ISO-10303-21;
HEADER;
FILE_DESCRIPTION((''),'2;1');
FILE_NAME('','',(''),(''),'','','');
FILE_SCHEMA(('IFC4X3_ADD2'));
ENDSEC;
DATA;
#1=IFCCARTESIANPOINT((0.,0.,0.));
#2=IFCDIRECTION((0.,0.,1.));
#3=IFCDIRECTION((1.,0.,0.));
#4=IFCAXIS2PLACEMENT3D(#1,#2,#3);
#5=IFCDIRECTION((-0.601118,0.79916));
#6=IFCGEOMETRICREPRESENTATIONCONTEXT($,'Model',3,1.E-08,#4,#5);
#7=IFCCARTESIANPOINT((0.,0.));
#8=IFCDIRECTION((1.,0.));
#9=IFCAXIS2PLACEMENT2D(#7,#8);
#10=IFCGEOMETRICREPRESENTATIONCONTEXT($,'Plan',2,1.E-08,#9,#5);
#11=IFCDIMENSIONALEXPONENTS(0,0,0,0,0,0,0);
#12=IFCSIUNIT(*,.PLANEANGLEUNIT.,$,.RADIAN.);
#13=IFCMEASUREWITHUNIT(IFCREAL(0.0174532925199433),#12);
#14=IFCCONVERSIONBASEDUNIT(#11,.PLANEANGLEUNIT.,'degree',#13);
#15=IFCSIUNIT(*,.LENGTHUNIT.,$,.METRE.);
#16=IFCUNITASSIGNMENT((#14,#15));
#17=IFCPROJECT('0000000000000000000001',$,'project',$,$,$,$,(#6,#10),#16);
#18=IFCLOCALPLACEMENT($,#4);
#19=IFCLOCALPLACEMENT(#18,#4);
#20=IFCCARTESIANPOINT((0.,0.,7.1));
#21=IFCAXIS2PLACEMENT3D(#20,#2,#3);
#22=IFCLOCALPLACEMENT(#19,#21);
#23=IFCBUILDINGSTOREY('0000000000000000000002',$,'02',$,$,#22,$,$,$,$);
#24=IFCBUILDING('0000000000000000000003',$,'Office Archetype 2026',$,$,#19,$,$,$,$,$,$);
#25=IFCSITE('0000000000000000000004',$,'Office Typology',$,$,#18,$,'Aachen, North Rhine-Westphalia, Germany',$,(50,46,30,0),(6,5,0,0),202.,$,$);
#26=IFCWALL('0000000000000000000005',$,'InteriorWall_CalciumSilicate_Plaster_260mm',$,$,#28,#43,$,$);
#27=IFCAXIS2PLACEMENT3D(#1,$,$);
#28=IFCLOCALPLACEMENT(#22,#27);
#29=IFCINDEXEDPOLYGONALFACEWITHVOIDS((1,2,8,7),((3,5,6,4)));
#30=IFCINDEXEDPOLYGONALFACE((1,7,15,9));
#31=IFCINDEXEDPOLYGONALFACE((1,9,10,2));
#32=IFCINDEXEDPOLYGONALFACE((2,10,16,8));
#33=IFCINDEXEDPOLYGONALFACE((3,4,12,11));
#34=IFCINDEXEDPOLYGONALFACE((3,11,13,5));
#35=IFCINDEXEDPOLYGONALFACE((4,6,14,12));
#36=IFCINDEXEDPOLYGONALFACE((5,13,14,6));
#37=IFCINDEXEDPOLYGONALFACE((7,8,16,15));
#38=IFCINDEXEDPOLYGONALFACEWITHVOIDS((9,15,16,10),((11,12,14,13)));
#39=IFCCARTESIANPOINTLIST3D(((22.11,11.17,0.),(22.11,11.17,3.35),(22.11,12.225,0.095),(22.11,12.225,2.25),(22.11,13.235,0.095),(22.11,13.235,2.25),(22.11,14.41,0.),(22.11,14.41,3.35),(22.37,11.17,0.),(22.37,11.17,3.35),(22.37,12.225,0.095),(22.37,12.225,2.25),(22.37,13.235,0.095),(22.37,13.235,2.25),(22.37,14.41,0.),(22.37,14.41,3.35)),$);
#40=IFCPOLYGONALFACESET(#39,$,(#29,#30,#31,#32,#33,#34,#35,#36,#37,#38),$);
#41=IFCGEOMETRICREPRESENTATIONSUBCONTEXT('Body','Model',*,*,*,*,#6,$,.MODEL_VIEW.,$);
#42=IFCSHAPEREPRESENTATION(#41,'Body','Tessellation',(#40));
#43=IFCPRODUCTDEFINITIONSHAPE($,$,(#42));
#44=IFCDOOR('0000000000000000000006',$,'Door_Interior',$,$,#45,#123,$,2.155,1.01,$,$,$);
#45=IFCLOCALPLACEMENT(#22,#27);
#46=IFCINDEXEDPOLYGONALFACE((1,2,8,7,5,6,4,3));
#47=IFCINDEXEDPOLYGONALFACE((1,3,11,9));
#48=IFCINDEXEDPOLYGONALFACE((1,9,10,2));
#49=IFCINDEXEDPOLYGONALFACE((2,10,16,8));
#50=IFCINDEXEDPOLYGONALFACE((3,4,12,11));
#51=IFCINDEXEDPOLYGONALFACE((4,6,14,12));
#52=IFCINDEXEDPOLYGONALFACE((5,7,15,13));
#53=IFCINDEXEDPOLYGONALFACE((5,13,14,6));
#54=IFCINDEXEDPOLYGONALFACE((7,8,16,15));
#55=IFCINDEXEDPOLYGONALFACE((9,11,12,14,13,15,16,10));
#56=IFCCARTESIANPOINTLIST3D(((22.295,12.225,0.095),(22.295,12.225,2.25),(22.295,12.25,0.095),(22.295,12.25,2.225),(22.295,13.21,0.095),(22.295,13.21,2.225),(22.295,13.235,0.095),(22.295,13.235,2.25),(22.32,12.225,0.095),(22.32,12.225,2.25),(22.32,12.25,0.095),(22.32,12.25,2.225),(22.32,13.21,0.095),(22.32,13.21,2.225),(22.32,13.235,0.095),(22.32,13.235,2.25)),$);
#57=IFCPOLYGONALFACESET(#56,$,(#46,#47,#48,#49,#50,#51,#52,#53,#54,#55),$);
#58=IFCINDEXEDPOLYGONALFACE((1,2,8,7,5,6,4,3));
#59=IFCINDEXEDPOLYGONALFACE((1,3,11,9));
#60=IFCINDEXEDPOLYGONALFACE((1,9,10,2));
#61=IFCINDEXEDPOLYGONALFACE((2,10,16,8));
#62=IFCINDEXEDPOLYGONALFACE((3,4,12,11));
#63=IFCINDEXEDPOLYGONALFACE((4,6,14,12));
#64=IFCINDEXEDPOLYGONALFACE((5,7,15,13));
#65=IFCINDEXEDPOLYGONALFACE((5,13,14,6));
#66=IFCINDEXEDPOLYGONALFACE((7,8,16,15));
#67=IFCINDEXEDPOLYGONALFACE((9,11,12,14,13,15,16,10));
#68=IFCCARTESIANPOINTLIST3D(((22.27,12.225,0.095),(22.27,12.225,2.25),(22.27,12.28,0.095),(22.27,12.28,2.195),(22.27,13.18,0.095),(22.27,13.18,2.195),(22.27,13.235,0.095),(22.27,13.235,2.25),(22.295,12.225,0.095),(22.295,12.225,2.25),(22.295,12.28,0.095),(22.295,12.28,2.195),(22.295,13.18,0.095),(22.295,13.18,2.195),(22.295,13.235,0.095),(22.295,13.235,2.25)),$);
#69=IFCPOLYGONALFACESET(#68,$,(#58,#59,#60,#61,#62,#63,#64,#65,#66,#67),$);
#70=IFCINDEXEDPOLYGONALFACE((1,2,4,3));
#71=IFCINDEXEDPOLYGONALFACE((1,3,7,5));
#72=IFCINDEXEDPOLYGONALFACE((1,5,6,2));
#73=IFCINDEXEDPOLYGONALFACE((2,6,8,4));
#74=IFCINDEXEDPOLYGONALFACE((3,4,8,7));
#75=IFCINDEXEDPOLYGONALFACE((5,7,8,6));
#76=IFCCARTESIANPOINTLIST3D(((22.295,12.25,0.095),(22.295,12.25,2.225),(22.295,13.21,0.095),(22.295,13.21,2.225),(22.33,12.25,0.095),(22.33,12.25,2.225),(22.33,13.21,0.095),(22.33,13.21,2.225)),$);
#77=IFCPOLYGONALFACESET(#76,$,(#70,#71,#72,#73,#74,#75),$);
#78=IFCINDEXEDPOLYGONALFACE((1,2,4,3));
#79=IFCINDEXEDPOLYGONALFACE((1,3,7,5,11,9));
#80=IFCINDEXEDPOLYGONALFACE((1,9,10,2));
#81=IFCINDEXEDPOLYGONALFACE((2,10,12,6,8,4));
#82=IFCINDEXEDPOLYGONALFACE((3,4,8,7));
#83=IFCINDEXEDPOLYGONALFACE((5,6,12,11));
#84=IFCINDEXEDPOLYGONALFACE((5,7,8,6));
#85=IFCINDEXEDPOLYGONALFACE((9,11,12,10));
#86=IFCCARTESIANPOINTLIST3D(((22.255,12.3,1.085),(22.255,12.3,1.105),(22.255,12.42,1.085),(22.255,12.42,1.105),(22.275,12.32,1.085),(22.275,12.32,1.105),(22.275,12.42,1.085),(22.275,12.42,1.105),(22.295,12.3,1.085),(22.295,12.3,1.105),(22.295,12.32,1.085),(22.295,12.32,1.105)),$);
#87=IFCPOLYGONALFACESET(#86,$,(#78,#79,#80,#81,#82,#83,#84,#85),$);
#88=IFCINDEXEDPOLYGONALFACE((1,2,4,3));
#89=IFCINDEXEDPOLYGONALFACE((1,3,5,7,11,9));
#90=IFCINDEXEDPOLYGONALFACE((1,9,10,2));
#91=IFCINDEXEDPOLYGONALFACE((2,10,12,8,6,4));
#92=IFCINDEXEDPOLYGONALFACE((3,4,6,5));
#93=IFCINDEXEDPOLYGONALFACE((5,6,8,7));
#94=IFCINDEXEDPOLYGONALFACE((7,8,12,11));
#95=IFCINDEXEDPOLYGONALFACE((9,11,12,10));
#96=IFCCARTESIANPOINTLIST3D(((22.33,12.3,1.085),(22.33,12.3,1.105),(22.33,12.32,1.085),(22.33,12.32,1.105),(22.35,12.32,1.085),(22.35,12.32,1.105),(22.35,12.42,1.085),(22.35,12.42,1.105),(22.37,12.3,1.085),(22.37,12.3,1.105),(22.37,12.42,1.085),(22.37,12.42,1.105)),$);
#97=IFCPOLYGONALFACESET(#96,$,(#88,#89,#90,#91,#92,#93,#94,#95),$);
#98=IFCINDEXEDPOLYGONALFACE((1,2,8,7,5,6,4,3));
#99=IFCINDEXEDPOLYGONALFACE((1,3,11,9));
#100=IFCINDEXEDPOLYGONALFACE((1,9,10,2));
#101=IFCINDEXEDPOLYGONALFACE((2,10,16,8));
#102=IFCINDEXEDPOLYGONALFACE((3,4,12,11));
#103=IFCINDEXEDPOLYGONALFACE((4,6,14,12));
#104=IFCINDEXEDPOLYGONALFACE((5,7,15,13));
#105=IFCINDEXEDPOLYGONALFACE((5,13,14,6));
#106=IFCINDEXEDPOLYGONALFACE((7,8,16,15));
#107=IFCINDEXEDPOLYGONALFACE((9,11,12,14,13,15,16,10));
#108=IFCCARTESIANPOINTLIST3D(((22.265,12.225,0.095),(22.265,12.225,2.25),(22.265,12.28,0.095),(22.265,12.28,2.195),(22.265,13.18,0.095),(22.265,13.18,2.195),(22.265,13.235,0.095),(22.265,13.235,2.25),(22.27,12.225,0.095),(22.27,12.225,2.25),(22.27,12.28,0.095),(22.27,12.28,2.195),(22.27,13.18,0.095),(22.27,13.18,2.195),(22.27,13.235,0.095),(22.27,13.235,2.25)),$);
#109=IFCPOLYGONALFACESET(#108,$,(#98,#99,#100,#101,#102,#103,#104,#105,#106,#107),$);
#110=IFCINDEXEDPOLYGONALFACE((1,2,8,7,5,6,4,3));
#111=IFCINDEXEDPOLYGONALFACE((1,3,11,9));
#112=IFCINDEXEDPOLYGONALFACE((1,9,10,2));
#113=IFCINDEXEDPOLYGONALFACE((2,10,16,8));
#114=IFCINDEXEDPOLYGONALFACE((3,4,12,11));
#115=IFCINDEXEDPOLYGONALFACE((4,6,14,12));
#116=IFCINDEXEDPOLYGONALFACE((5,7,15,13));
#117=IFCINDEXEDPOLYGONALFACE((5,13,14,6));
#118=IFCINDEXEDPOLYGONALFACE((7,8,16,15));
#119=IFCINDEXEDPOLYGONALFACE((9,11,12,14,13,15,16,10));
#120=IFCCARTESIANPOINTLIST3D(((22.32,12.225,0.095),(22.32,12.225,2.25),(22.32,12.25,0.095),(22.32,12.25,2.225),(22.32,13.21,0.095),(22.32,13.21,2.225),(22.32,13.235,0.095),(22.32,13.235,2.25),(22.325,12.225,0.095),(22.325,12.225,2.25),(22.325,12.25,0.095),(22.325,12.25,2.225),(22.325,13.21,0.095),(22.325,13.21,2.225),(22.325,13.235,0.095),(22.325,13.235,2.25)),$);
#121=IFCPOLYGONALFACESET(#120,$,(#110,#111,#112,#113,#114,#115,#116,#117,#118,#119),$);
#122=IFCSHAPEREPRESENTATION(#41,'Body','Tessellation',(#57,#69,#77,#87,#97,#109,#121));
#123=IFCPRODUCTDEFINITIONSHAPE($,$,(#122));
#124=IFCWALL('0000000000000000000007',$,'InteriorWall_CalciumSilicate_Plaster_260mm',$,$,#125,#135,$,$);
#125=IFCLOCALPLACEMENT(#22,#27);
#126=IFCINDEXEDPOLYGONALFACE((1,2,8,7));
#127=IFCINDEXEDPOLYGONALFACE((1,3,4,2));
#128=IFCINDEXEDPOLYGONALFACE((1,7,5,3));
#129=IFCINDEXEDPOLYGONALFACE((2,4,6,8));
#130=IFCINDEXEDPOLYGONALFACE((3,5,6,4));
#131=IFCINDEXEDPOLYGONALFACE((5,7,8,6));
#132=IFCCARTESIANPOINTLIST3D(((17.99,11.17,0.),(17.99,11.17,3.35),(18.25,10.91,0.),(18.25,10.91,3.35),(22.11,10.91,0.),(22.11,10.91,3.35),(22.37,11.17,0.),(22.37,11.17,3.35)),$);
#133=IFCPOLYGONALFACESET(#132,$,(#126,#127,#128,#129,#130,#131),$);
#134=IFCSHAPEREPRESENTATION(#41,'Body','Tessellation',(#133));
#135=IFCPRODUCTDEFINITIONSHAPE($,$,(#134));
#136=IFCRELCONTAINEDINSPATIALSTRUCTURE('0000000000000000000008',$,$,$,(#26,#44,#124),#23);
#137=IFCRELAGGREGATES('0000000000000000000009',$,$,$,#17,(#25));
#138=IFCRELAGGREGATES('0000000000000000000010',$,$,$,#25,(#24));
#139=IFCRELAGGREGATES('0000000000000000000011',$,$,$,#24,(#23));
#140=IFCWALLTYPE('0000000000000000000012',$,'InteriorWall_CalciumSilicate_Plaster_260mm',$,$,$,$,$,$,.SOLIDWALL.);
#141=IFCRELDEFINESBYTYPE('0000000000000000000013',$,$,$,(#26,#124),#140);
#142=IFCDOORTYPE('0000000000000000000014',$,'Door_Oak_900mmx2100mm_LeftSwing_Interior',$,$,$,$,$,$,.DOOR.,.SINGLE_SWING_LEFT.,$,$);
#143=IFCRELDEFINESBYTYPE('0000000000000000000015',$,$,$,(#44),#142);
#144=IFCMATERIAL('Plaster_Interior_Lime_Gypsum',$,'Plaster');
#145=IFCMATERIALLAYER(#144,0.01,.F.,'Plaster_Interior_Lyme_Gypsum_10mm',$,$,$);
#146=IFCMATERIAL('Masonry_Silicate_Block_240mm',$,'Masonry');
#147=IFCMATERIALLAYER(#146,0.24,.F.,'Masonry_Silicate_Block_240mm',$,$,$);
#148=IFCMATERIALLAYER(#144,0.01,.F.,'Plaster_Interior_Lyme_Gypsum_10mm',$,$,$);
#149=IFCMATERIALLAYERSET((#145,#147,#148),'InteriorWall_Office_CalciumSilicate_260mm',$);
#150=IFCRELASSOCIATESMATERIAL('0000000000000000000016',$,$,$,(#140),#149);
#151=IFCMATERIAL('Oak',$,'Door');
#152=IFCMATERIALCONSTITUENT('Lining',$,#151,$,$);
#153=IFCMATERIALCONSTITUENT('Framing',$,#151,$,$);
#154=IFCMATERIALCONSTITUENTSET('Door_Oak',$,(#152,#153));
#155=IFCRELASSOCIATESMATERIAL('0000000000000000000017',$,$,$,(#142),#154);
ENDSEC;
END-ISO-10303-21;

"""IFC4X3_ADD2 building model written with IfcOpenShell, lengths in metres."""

from ifc_helpers import new_model, entity, si_unit, converted_unit, direction, frame, origin_with_axes, origin_2d_with_axis, place, context, subcontext, project, spatial, line, indexed_curve, outline, extrude, source, transform, mapped, material, layer, layer_set, constituent, constituent_set, type_object, type_shapes, element, fill, save


model = new_model("IFC4X3_ADD2")

# Units and contexts
model_context = context("Model", 3, precision=1e-08, world=origin_with_axes(), true_north=direction((-0.601118, 0.79916)))
plan_context = context("Plan", 2, precision=1e-08, world=origin_2d_with_axis(), true_north=direction((-0.601118, 0.79916)))
body_context = subcontext(model_context, "Body", "Model", "MODEL_VIEW")
ifc_project = project(units=[converted_unit("PLANEANGLEUNIT", "degree", entity("IfcReal", 0.0174532925199433), si_unit("PLANEANGLEUNIT", "RADIAN"), dimensions=[0, 0, 0, 0, 0, 0, 0]), si_unit("LENGTHUNIT", "METRE")], contexts=[model_context, plan_context])

# Site, building, storey
site_placement = place(None, origin_with_axes())
site = spatial("IfcSite", under=ifc_project, at=site_placement, Name="Office Typology", LongName="Aachen, North Rhine-Westphalia, Germany", RefLatitude=(50, 46, 30, 0), RefLongitude=(6, 5, 0, 0), RefElevation=202.0)
building_placement = place(site_placement, origin_with_axes())
building = spatial("IfcBuilding", under=site, at=building_placement, Name="Office Archetype 2026")
storey_placement = place(building_placement, frame((0.0, 0.0, 7.1), z_axis=(0.0, 0.0, 1.0), x_axis=(1.0, 0.0, 0.0)))
storey = spatial("IfcBuildingStorey", under=building, at=storey_placement, Name="02")

# Wall, opening, door
ifc_material_1 = material(Name="Plaster_Interior_Lime_Gypsum", Category="Plaster")
ifc_layer_1 = layer(ifc_material_1, 0.01, ventilated=False, Name="Plaster_Interior_Lyme_Gypsum_10mm")
ifc_material_2 = material(Name="Masonry_Silicate_Block_240mm", Category="Masonry")
ifc_layer_2 = layer(ifc_material_2, 0.24, ventilated=False, Name="Masonry_Silicate_Block_240mm")
ifc_layer_3 = layer(ifc_material_1, 0.01, ventilated=False, Name="Plaster_Interior_Lyme_Gypsum_10mm")
ifc_layer_set = layer_set([ifc_layer_1, ifc_layer_2, ifc_layer_3], Name="InteriorWall_Office_CalciumSilicate_260mm")
wall_type = type_object("IfcWallType", Name="InteriorWall_CalciumSilicate_Plaster_260mm", PredefinedType="SOLIDWALL", material=ifc_layer_set)
wall_1_placement = place(storey_placement, frame((22.37, 11.17, 0.0), z_axis=(0.0, 0.0, 1.0), x_axis=(0.0, 1.0, 0.0)))
wall_1 = element("IfcWall", 1, at=wall_1_placement, inside=storey, type_object=wall_type, Name="InteriorWall_CalciumSilicate_Plaster_260mm", context=body_context, shape_type="SweptSolid", body=[
    extrude(outline(indexed_curve([(0.0, 0.0), (0.0, 0.26), (3.24, 0.26), (3.24, 0.0)], segments=[line(1, 2, 3, 4, 1)])), origin_with_axes(), (0.0, 0.0, 1.0), 3.35),
])
shared_shape_1 = source(origin_with_axes(), body_context, "Body", "SweptSolid", [
    extrude(outline(indexed_curve([(0.0, 2.155), (1.01, 2.155), (1.01, 0.0), (0.0, 0.0), (0.0, 2.155)])), frame((0.0, -0.015, 0.0), z_axis=(0.0, -1.0, 0.0), x_axis=(1.0, 0.0, 0.0)), (0.0, 0.0, -1.0), 0.26),
])
opening_placement = place(wall_1_placement, frame((2.065, 0.245, 0.095), z_axis=(0.0, 0.0, 1.0), x_axis=(-1.0, 0.0, 0.0)))
opening = element("IfcOpeningElement", 2, at=opening_placement, cuts=wall_1, PredefinedType="OPENING", context=body_context, shape_type="MappedRepresentation", body=[
    mapped(shared_shape_1, transform((0.0, 0.0, 0.0), x_axis=(1.0, 0.0, 0.0), y_axis=(0.0, 1.0, 0.0), z_axis=(0.0, 0.0, 1.0), scale=1.0)),
])
ifc_material_3 = material(Name="Oak", Category="Door")
ifc_constituent_1 = constituent(ifc_material_3, Name="Lining")
ifc_constituent_2 = constituent(ifc_material_3, Name="Framing")
ifc_constituent_set = constituent_set(constituents=[ifc_constituent_1, ifc_constituent_2], Name="Door_Oak")
door_type = type_object("IfcDoorType", Name="Door_Oak_900mmx2100mm_LeftSwing_Interior", OperationType="SINGLE_SWING_LEFT", PredefinedType="DOOR", material=ifc_constituent_set)
shared_shape_2 = source(origin_with_axes(), body_context, "Body", "SweptSolid", [
    extrude(outline(indexed_curve([(0.0, 0.0), (0.0, 2.155), (1.01, 2.155), (1.01, 0.0), (0.985, 0.0), (0.985, 2.13), (0.025, 2.13), (0.025, 0.0)], segments=[line(1, 2, 3, 4, 5, 6, 7, 8, 1)])), frame((0.0, 0.025, 0.0), z_axis=(0.0, -1.0, 0.0), x_axis=(1.0, 0.0, 0.0)), (0.0, 0.0, -1.0), 0.025),
    extrude(outline(indexed_curve([(0.0, 0.0), (0.0, 2.155), (1.01, 2.155), (1.01, 0.0), (0.955, 0.0), (0.955, 2.1), (0.055, 2.1), (0.055, 0.0)], segments=[line(1, 2, 3, 4, 5, 6, 7, 8, 1)])), frame((0.0, 0.0, 0.0), z_axis=(0.0, -1.0, 0.0), x_axis=(1.0, 0.0, 0.0)), (0.0, 0.0, -1.0), 0.025),
    extrude(outline(indexed_curve([(0.0, 0.0), (0.96, 0.0), (0.96, 0.035), (0.0, 0.035)], segments=[line(1, 2, 3, 4, 1)])), frame((0.025, 0.025, 0.0), z_axis=(0.0, 0.0, 1.0), x_axis=(1.0, 0.0, 0.0)), (0.0, 0.0, 1.0), 2.13),
    extrude(outline(indexed_curve([(0.0, 0.0), (0.0, -0.04), (-0.12, -0.04), (-0.12, -0.02), (-0.02, -0.02), (-0.02, 0.0)], segments=[line(1, 2, 3, 4, 5, 6, 1)])), frame((0.935, 0.025, 0.99), z_axis=(0.0, 0.0, 1.0), x_axis=(1.0, 0.0, 0.0)), (0.0, 0.0, 1.0), 0.02),
    extrude(outline(indexed_curve([(0.0, 0.0), (0.0, 0.04), (-0.12, 0.04), (-0.12, 0.02), (-0.02, 0.02), (-0.02, 0.0)], segments=[line(1, 2, 3, 4, 5, 6, 1)])), frame((0.935, 0.06, 0.99), z_axis=(0.0, 0.0, 1.0), x_axis=(1.0, 0.0, 0.0)), (0.0, 0.0, 1.0), 0.02),
    extrude(outline(indexed_curve([(0.0, 0.0), (0.0, 2.155), (1.01, 2.155), (1.01, 0.0), (0.955, 0.0), (0.955, 2.1), (0.055, 2.1), (0.055, 0.0)], segments=[line(1, 2, 3, 4, 5, 6, 7, 8, 1)])), frame((0.0, -0.005, 0.0), z_axis=(0.0, -1.0, 0.0), x_axis=(1.0, 0.0, 0.0)), (0.0, 0.0, -1.0), 0.005),
    extrude(outline(indexed_curve([(0.0, 0.0), (0.0, 2.155), (1.01, 2.155), (1.01, 0.0), (0.985, 0.0), (0.985, 2.13), (0.025, 2.13), (0.025, 0.0)], segments=[line(1, 2, 3, 4, 5, 6, 7, 8, 1)])), frame((0.0, 0.05, 0.0), z_axis=(0.0, -1.0, 0.0), x_axis=(1.0, 0.0, 0.0)), (0.0, 0.0, -1.0), 0.005),
])
type_shapes(door_type, [shared_shape_2])
door_placement = place(opening_placement, frame((0.0, 0.145, 0.0), z_axis=(0.0, 0.0, 1.0), x_axis=(1.0, 0.0, 0.0)))
door = element("IfcDoor", 3, at=door_placement, inside=storey, type_object=door_type, Name="Door_Interior", OverallHeight=2.155, OverallWidth=1.01, context=body_context, shape_type="MappedRepresentation", body=[
    mapped(shared_shape_2, transform((0.0, 0.0, 0.0), x_axis=(1.0, 0.0, 0.0), y_axis=(0.0, 1.0, 0.0), z_axis=(0.0, 0.0, 1.0), scale=1.0)),
])
fill(opening, door)

# Wall
wall_2_placement = place(storey_placement, frame((22.37, 11.17, 0.0), z_axis=(0.0, 0.0, 1.0), x_axis=(-1.0, 0.0, 0.0)))
element("IfcWall", 4, at=wall_2_placement, inside=storey, type_object=wall_type, Name="InteriorWall_CalciumSilicate_Plaster_260mm", context=body_context, shape_type="SweptSolid", body=[
    extrude(outline(indexed_curve([(0.0, 0.0), (0.26, 0.26), (4.12, 0.26), (4.38, 0.0)], segments=[line(1, 2, 3, 4, 1)])), origin_with_axes(), (0.0, 0.0, 1.0), 3.35),
])

save(model, "model.ifc")
